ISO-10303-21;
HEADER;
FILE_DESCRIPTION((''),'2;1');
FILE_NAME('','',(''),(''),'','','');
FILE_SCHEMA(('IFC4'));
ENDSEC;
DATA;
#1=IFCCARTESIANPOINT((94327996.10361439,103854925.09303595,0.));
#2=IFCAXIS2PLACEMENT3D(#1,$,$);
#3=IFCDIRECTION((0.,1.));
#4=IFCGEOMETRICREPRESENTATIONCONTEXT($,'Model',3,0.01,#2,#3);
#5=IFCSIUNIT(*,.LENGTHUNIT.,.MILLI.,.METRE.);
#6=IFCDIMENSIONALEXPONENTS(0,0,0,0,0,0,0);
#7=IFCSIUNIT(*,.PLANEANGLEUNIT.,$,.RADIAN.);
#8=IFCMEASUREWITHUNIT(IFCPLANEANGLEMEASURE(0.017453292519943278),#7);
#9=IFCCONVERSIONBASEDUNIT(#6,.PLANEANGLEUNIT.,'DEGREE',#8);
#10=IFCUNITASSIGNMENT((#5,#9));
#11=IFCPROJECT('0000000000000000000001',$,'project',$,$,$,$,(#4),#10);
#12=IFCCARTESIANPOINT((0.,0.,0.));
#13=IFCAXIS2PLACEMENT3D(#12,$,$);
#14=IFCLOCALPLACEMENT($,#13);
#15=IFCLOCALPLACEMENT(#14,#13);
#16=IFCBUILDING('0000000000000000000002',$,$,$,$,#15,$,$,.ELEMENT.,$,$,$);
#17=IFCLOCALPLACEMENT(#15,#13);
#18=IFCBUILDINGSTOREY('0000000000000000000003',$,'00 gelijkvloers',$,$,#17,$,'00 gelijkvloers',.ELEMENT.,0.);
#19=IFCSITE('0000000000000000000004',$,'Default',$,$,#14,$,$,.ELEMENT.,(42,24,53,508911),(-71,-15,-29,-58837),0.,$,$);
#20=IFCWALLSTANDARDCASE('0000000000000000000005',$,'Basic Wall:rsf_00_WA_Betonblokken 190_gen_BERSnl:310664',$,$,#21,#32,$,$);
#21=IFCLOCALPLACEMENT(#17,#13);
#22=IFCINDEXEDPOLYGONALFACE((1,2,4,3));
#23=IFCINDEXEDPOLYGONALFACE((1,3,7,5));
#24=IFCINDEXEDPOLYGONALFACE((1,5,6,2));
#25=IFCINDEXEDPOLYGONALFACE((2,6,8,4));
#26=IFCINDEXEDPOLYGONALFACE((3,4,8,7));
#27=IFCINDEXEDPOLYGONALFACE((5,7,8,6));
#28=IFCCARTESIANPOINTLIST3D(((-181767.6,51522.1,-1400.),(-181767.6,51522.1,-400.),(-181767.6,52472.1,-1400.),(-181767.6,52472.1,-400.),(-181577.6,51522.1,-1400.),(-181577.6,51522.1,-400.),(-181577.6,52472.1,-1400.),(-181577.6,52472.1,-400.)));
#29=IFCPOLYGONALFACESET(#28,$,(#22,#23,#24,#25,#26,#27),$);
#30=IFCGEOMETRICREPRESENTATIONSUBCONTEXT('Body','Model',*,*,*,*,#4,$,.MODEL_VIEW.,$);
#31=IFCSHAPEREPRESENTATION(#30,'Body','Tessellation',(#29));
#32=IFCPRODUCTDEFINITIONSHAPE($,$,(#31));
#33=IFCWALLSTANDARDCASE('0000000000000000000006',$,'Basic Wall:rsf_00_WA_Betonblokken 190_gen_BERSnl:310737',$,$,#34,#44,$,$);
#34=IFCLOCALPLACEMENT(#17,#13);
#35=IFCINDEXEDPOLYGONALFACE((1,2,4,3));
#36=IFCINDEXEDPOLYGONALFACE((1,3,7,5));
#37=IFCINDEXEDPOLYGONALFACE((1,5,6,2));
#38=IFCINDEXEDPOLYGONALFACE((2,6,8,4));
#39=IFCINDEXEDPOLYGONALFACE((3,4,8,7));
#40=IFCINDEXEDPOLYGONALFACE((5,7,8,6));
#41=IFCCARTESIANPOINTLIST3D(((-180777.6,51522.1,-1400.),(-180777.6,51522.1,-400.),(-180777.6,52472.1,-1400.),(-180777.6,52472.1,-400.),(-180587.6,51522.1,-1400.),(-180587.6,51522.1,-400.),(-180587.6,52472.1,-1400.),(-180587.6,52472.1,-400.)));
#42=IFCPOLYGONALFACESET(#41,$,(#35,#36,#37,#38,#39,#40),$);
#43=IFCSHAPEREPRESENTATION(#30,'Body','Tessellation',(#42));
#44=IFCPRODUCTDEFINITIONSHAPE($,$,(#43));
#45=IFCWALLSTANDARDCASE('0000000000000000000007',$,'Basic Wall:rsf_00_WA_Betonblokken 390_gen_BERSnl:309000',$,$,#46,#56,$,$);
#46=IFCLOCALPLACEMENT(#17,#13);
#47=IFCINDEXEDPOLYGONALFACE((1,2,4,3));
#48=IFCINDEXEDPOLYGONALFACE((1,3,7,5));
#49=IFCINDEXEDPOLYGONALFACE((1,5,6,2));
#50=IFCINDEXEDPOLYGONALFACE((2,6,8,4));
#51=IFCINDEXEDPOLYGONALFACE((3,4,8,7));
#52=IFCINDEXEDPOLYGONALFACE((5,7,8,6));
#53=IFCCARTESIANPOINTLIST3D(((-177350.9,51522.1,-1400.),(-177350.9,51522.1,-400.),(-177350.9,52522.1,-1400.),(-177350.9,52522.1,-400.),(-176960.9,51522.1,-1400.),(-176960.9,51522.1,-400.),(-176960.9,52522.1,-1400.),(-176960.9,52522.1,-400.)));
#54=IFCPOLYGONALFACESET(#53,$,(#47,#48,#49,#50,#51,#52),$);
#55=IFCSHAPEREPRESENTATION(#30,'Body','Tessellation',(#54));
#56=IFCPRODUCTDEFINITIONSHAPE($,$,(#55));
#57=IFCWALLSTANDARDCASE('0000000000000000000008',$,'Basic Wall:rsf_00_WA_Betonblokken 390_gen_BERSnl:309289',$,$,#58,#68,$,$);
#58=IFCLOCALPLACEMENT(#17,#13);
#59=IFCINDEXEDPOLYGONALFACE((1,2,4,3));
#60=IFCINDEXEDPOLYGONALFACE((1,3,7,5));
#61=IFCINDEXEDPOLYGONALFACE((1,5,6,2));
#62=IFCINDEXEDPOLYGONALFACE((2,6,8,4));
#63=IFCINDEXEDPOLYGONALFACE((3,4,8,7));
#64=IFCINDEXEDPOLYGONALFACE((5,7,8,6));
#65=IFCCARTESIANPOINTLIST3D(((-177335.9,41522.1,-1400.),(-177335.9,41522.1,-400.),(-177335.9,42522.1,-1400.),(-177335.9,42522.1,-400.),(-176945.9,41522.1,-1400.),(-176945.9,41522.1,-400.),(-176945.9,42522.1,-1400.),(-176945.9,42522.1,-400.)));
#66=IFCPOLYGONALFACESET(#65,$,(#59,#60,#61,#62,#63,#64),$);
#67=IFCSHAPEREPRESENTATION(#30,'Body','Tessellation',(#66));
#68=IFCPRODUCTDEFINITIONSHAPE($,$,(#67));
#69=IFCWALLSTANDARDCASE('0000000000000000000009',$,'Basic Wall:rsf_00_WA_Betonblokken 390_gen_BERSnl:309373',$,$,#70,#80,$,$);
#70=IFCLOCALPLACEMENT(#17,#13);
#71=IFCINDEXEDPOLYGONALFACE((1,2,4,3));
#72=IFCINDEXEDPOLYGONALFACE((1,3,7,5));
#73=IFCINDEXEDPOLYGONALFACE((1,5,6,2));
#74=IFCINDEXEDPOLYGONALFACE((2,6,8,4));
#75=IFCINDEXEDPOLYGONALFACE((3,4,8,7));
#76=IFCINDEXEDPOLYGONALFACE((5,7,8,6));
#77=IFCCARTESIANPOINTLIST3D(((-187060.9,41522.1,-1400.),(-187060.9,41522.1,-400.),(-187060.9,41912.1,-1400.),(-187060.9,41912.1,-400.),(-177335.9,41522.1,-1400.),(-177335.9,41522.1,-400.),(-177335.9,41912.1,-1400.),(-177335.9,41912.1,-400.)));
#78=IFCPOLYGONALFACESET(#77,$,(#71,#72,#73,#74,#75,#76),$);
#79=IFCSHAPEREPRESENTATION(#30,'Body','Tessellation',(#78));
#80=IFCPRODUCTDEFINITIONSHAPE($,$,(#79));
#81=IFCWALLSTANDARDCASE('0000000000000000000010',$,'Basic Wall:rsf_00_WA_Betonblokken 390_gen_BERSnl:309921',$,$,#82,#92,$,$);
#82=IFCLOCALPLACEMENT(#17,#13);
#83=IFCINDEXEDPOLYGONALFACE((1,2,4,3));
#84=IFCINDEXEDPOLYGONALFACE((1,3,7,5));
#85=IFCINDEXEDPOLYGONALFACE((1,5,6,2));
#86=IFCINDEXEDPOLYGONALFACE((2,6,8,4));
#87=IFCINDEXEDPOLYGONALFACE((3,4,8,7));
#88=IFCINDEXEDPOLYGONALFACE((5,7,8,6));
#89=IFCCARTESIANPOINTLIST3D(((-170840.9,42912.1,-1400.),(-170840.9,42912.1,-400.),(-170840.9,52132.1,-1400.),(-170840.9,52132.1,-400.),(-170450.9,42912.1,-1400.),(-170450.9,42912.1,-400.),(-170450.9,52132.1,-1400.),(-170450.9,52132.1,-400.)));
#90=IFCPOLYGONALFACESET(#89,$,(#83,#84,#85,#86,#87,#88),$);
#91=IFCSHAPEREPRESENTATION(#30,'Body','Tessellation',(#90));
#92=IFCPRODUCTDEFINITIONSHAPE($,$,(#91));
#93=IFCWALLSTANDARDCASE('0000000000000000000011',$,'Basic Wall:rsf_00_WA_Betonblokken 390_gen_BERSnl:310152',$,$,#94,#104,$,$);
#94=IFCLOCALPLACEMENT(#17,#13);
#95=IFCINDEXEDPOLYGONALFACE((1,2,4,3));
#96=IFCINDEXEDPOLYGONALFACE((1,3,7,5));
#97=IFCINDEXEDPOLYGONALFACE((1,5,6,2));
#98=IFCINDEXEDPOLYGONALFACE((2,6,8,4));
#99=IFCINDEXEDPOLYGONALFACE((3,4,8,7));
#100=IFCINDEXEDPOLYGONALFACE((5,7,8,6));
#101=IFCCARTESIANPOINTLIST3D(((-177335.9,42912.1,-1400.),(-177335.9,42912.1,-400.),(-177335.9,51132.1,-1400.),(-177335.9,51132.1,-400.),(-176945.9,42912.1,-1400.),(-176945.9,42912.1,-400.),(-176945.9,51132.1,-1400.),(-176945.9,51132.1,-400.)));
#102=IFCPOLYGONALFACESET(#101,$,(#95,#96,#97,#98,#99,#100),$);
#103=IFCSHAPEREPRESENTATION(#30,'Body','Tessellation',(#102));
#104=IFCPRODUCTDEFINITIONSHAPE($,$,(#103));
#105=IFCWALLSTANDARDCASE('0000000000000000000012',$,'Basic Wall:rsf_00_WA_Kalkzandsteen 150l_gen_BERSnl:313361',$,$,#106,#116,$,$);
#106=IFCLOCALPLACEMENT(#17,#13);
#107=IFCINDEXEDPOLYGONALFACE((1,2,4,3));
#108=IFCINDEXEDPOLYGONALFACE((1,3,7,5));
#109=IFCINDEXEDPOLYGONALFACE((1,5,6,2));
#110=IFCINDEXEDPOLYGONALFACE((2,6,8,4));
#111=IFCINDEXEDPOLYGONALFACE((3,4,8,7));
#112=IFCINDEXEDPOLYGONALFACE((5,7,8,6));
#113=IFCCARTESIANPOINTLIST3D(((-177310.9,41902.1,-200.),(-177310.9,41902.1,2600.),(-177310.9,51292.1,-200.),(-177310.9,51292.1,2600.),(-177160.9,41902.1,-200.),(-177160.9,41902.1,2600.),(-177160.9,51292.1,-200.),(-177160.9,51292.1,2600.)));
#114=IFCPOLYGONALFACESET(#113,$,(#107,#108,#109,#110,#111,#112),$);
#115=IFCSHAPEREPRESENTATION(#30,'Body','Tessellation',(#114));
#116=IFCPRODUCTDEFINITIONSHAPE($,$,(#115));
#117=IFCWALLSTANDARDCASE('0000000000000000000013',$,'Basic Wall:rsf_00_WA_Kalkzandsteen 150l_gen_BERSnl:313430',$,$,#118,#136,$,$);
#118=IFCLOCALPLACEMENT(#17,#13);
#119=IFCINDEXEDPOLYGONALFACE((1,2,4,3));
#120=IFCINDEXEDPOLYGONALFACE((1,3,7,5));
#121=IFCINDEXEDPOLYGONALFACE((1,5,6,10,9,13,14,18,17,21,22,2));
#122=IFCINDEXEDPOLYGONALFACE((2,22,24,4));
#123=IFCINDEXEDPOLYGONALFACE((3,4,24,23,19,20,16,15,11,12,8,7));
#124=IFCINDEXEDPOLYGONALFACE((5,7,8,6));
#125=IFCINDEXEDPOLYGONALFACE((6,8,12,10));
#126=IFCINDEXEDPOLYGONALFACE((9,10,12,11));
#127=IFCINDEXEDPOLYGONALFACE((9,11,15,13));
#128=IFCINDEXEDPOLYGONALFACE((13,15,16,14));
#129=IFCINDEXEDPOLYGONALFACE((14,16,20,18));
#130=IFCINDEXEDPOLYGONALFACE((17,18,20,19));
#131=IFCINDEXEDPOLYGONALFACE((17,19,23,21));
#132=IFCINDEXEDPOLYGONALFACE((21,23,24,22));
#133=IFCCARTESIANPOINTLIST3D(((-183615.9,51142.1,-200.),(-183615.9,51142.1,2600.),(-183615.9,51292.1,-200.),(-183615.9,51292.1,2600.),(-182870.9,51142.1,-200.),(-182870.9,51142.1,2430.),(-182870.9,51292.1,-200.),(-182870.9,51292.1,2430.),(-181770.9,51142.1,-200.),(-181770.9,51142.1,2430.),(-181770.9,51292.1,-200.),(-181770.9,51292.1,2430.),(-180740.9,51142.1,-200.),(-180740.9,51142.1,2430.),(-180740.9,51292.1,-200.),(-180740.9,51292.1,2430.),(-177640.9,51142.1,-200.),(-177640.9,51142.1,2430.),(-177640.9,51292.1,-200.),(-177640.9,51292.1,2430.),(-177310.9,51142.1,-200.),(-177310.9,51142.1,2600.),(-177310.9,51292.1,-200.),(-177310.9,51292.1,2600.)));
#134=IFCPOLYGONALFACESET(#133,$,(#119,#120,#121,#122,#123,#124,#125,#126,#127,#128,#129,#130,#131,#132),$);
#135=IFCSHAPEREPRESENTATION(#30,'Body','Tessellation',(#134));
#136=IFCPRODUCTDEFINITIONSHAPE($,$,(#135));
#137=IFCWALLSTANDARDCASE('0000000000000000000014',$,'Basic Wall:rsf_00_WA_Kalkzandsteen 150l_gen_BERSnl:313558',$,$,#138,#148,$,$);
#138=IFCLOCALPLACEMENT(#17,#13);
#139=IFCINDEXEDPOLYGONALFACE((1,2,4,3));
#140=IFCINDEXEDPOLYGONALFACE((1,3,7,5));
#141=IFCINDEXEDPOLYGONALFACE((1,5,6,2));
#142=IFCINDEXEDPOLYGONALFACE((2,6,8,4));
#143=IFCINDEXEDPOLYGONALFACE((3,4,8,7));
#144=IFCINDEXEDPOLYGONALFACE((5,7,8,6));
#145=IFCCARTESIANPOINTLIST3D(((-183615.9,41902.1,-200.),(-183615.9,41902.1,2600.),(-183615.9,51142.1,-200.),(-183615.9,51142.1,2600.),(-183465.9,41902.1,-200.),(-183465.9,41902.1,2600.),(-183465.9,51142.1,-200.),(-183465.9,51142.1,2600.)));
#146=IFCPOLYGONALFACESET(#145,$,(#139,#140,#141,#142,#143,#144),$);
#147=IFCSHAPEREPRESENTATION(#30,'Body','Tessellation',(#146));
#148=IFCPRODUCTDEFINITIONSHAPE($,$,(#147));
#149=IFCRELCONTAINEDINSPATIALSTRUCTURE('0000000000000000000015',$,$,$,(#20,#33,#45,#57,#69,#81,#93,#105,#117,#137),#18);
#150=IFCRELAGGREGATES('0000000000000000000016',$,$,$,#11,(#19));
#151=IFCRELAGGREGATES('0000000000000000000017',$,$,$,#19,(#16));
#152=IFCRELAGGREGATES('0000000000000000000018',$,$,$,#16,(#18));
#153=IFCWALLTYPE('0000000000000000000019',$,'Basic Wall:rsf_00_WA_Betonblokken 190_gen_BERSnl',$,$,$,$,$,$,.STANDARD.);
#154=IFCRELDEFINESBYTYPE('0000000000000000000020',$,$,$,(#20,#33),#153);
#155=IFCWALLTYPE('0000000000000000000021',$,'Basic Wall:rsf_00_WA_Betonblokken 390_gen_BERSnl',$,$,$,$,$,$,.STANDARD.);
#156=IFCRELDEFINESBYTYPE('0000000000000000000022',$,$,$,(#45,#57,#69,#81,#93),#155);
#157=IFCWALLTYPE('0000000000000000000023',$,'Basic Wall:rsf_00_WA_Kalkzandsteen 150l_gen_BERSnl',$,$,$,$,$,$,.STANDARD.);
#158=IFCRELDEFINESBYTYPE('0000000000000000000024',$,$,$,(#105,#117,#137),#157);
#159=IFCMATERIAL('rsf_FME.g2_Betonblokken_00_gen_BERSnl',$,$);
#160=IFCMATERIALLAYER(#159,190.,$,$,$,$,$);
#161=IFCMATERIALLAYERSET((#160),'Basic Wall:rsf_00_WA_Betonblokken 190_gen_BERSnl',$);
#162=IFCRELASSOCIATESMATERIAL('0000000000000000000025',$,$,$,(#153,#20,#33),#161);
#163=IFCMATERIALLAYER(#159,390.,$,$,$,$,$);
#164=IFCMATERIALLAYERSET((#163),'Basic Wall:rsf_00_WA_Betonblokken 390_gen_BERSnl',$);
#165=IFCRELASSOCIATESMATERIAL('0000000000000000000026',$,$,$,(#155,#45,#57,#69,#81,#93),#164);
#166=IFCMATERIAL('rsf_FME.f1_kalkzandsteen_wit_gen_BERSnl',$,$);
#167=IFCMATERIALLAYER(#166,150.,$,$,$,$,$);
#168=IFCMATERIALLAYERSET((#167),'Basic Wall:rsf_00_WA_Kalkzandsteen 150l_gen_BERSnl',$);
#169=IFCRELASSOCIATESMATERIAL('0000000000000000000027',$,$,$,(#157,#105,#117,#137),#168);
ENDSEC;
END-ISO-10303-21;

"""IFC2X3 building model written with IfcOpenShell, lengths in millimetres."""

from ifc_helpers import new_model, entity, si_unit, converted_unit, direction, frame, frame_2d, origin, place, context, subcontext, project, spatial, polyline, rectangle, extrude, clip, bounded_halfspace, material, layer, layer_set, layer_usage, type_object, element, save


model = new_model("IFC2X3")

# Units and contexts
model_context = context("Model", 3, precision=0.01, world=frame((94327996.10361439, 103854925.09303595, 0.0)), true_north=direction((0.0, 1.0)))
body_context = subcontext(model_context, "Body", "Model", "MODEL_VIEW")
ifc_project = project(units=[si_unit("LENGTHUNIT", "METRE", prefix="MILLI"), converted_unit("PLANEANGLEUNIT", "DEGREE", entity("IfcPlaneAngleMeasure", 0.017453292519943278), si_unit("PLANEANGLEUNIT", "RADIAN"), dimensions=[0, 0, 0, 0, 0, 0, 0])], contexts=[model_context])

# Site, building, storey
site_placement = place(None, origin())
site = spatial("IfcSite", under=ifc_project, at=site_placement, Name="Default", CompositionType="ELEMENT", RefLatitude=(42, 24, 53, 508911), RefLongitude=(-71, -15, -29, -58837), RefElevation=0.0)
building_placement = place(site_placement, origin())
building = spatial("IfcBuilding", under=site, at=building_placement, CompositionType="ELEMENT")
storey_placement = place(building_placement, origin())
storey = spatial("IfcBuildingStorey", under=building, at=storey_placement, Name="00 gelijkvloers", LongName="00 gelijkvloers", CompositionType="ELEMENT", Elevation=0.0)

# Walls
ifc_material_1 = material(Name="rsf_FME.g2_Betonblokken_00_gen_BERSnl")
ifc_layer_1 = layer(ifc_material_1, 190.0)
ifc_layer_set_1 = layer_set([ifc_layer_1], Name="Basic Wall:rsf_00_WA_Betonblokken 190_gen_BERSnl")
ifc_layer_usage_1 = layer_usage(ifc_layer_set_1, "AXIS2", "NEGATIVE", 95.0)
wall_type_1 = type_object("IfcWallType", Name="Basic Wall:rsf_00_WA_Betonblokken 190_gen_BERSnl", PredefinedType="STANDARD", material=ifc_layer_set_1)
wall_1_placement = place(storey_placement, frame((-181672.6, 51522.1, -1400.0), z_axis=(0.0, 0.0, 1.0), x_axis=(0.0, 1.0, 0.0)))
element("IfcWallStandardCase", 1, at=wall_1_placement, inside=storey, type_object=wall_type_1, material=ifc_layer_usage_1, Name="Basic Wall:rsf_00_WA_Betonblokken 190_gen_BERSnl:310664", context=body_context, shape_type="SweptSolid", body=[
    extrude(rectangle(XDim=950.0, YDim=190.0, at=frame_2d((475.0, 0.0), x_axis=(-1.0, 0.0))), origin(), (0.0, 0.0, 1.0), 1000.0),
])
ifc_layer_usage_2 = layer_usage(ifc_layer_set_1, "AXIS2", "NEGATIVE", 95.0)
wall_2_placement = place(storey_placement, frame((-180682.6, 51522.1, -1400.0), z_axis=(0.0, 0.0, 1.0), x_axis=(0.0, 1.0, 0.0)))
element("IfcWallStandardCase", 2, at=wall_2_placement, inside=storey, type_object=wall_type_1, material=ifc_layer_usage_2, Name="Basic Wall:rsf_00_WA_Betonblokken 190_gen_BERSnl:310737", context=body_context, shape_type="SweptSolid", body=[
    extrude(rectangle(XDim=950.0, YDim=190.0, at=frame_2d((475.0, 0.0), x_axis=(-1.0, 0.0))), origin(), (0.0, 0.0, 1.0), 1000.0),
])
ifc_layer_2 = layer(ifc_material_1, 390.0)
ifc_layer_set_2 = layer_set([ifc_layer_2], Name="Basic Wall:rsf_00_WA_Betonblokken 390_gen_BERSnl")
ifc_layer_usage_3 = layer_usage(ifc_layer_set_2, "AXIS2", "NEGATIVE", 195.0)
wall_type_2 = type_object("IfcWallType", Name="Basic Wall:rsf_00_WA_Betonblokken 390_gen_BERSnl", PredefinedType="STANDARD", material=ifc_layer_set_2)
wall_3_placement = place(storey_placement, frame((-177155.9, 51522.1, -1400.0), z_axis=(0.0, 0.0, 1.0), x_axis=(0.0, 1.0, 0.0)))
element("IfcWallStandardCase", 3, at=wall_3_placement, inside=storey, type_object=wall_type_2, material=ifc_layer_usage_3, Name="Basic Wall:rsf_00_WA_Betonblokken 390_gen_BERSnl:309000", context=body_context, shape_type="SweptSolid", body=[
    extrude(rectangle(XDim=1000.0, YDim=390.0, at=frame_2d((500.0, 0.0), x_axis=(-1.0, 0.0))), origin(), (0.0, 0.0, 1.0), 1000.0),
])
ifc_layer_usage_4 = layer_usage(ifc_layer_set_2, "AXIS2", "NEGATIVE", 195.0)
wall_4_placement = place(storey_placement, frame((-177140.9, 42522.1, -1400.0), z_axis=(0.0, 0.0, 1.0), x_axis=(0.0, -1.0, 0.0)))
element("IfcWallStandardCase", 4, at=wall_4_placement, inside=storey, type_object=wall_type_2, material=ifc_layer_usage_4, Name="Basic Wall:rsf_00_WA_Betonblokken 390_gen_BERSnl:309289", context=body_context, shape_type="SweptSolid", body=[
    extrude(rectangle(XDim=1000.0, YDim=390.0, at=frame_2d((500.0, 0.0), x_axis=(-1.0, 0.0))), origin(), (0.0, 0.0, 1.0), 1000.0),
])
ifc_layer_usage_5 = layer_usage(ifc_layer_set_2, "AXIS2", "NEGATIVE", 195.0)
wall_5_placement = place(storey_placement, frame((-177335.9, 41717.1, -1400.0), z_axis=(0.0, 0.0, 1.0), x_axis=(-1.0, 0.0, 0.0)))
element("IfcWallStandardCase", 5, at=wall_5_placement, inside=storey, type_object=wall_type_2, material=ifc_layer_usage_5, Name="Basic Wall:rsf_00_WA_Betonblokken 390_gen_BERSnl:309373", context=body_context, shape_type="SweptSolid", body=[
    extrude(rectangle(XDim=9725.0, YDim=390.0, at=frame_2d((4862.5, 0.0), x_axis=(-1.0, 0.0))), origin(), (0.0, 0.0, 1.0), 1000.0),
])
ifc_layer_usage_6 = layer_usage(ifc_layer_set_2, "AXIS2", "POSITIVE", -195.0)
wall_6_placement = place(storey_placement, frame((-170645.9, 42912.1, -1400.0), z_axis=(0.0, 0.0, 1.0), x_axis=(0.0, 1.0, 0.0)))
element("IfcWallStandardCase", 6, at=wall_6_placement, inside=storey, type_object=wall_type_2, material=ifc_layer_usage_6, Name="Basic Wall:rsf_00_WA_Betonblokken 390_gen_BERSnl:309921", context=body_context, shape_type="SweptSolid", body=[
    extrude(rectangle(XDim=9220.0, YDim=390.0, at=frame_2d((4610.0, 0.0), x_axis=(-1.0, 0.0))), origin(), (0.0, 0.0, 1.0), 1000.0),
])
ifc_layer_usage_7 = layer_usage(ifc_layer_set_2, "AXIS2", "POSITIVE", -195.0)
wall_7_placement = place(storey_placement, frame((-177140.9, 42912.1, -1400.0), z_axis=(0.0, 0.0, 1.0), x_axis=(0.0, 1.0, 0.0)))
element("IfcWallStandardCase", 7, at=wall_7_placement, inside=storey, type_object=wall_type_2, material=ifc_layer_usage_7, Name="Basic Wall:rsf_00_WA_Betonblokken 390_gen_BERSnl:310152", context=body_context, shape_type="SweptSolid", body=[
    extrude(rectangle(XDim=8220.0, YDim=390.0, at=frame_2d((4110.0, 0.0), x_axis=(-1.0, 0.0))), origin(), (0.0, 0.0, 1.0), 1000.0),
])
ifc_material_2 = material(Name="rsf_FME.f1_kalkzandsteen_wit_gen_BERSnl")
ifc_layer_3 = layer(ifc_material_2, 150.0)
ifc_layer_set_3 = layer_set([ifc_layer_3], Name="Basic Wall:rsf_00_WA_Kalkzandsteen 150l_gen_BERSnl")
ifc_layer_usage_8 = layer_usage(ifc_layer_set_3, "AXIS2", "NEGATIVE", 75.0)
wall_type_3 = type_object("IfcWallType", Name="Basic Wall:rsf_00_WA_Kalkzandsteen 150l_gen_BERSnl", PredefinedType="STANDARD", material=ifc_layer_set_3)
wall_8_placement = place(storey_placement, frame((-177235.9, 41902.1, -200.0), z_axis=(0.0, 0.0, 1.0), x_axis=(0.0, 1.0, 0.0)))
element("IfcWallStandardCase", 8, at=wall_8_placement, inside=storey, type_object=wall_type_3, material=ifc_layer_usage_8, Name="Basic Wall:rsf_00_WA_Kalkzandsteen 150l_gen_BERSnl:313361", context=body_context, shape_type="Clipping", body=[
    clip(extrude(rectangle(XDim=9390.0, YDim=150.0, at=frame_2d((4695.0, 0.0), x_axis=(-1.0, 0.0))), origin(), (0.0, 0.0, 1.0), 2800.0), bounded_halfspace(frame((0.0, -75.0, 2800.0), z_axis=(0.0, 0.0, -1.0), x_axis=(0.0, -1.0, 0.0)), True, frame((0.0, -75.0, 2800.0)), polyline([(0.0, 0.0), (850.0, 0.0), (9390.0, 0.0), (9390.0, 150.0), (9240.0, 150.0), (0.0, 150.0), (0.0, 0.0)]))),
])

# Wall, openings
ifc_layer_usage_9 = layer_usage(ifc_layer_set_3, "AXIS2", "NEGATIVE", 75.0)
wall_9_placement = place(storey_placement, frame((-177310.9, 51217.1, -200.0), z_axis=(0.0, 0.0, 1.0), x_axis=(-1.0, 0.0, 0.0)))
wall_9 = element("IfcWallStandardCase", 9, at=wall_9_placement, inside=storey, type_object=wall_type_3, material=ifc_layer_usage_9, Name="Basic Wall:rsf_00_WA_Kalkzandsteen 150l_gen_BERSnl:313430", context=body_context, shape_type="Clipping", body=[
    clip(extrude(rectangle(XDim=6305.0, YDim=150.0, at=frame_2d((3152.5, 0.0), x_axis=(-1.0, 0.0))), origin(), (0.0, 0.0, 1.0), 2800.0), bounded_halfspace(frame((0.0, -75.0, 2800.0), z_axis=(0.0, 0.0, -1.0), x_axis=(-1.0, 0.0, 0.0)), True, frame((0.0, -75.0, 2800.0)), polyline([(0.0, 0.0), (6305.0, 0.0), (6305.0, 150.0), (6155.0, 150.0), (0.0, 150.0), (0.0, 0.0)]))),
])
opening_1_placement = place(wall_9_placement, frame((-177310.9, 51217.1, 200.0), z_axis=(0.0, 0.0, 1.0), x_axis=(-1.0, 0.0, 0.0)))
element("IfcOpeningElement", 10, at=opening_1_placement, cuts=wall_9, ObjectType="Opening", context=body_context, shape_type="SweptSolid", body=[
    extrude(rectangle(XDim=2630.0, YDim=3100.0, at=frame_2d((0.0, 0.0), x_axis=(0.0, 1.0))), frame((-179190.9, 52816.1, 1115.0), z_axis=(0.0, -1.0, 0.0), x_axis=(1.0, 0.0, 0.0)), (0.0, 0.0, 1.0), 3048.0),
])
opening_2_placement = place(wall_9_placement, frame((-177310.9, 51217.1, 200.0), z_axis=(0.0, 0.0, 1.0), x_axis=(-1.0, 0.0, 0.0)))
element("IfcOpeningElement", 11, at=opening_2_placement, cuts=wall_9, ObjectType="Opening", context=body_context, shape_type="SweptSolid", body=[
    extrude(rectangle(XDim=2630.0, YDim=1100.0, at=frame_2d((0.0, 0.0), x_axis=(1.0, 0.0))), frame((-182320.9, 52666.1, 1115.0), z_axis=(0.0, -1.0, 0.0), x_axis=(0.0, 0.0, 1.0)), (0.0, 0.0, 1.0), 3048.0),
])

# Wall
ifc_layer_usage_10 = layer_usage(ifc_layer_set_3, "AXIS2", "NEGATIVE", 75.0)
wall_10_placement = place(storey_placement, frame((-183540.9, 51142.1, -200.0), z_axis=(0.0, 0.0, 1.0), x_axis=(0.0, -1.0, 0.0)))
element("IfcWallStandardCase", 12, at=wall_10_placement, inside=storey, type_object=wall_type_3, material=ifc_layer_usage_10, Name="Basic Wall:rsf_00_WA_Kalkzandsteen 150l_gen_BERSnl:313558", context=body_context, shape_type="Clipping", body=[
    clip(extrude(rectangle(XDim=9240.0, YDim=150.0, at=frame_2d((4620.0, 0.0), x_axis=(-1.0, 0.0))), origin(), (0.0, 0.0, 1.0), 2800.0), bounded_halfspace(frame((0.0, -75.0, 2800.0), z_axis=(0.0, 0.0, -1.0), x_axis=(0.0, 1.0, 0.0)), True, frame((0.0, -75.0, 2800.0)), polyline([(0.0, 0.0), (9240.0, 0.0), (9240.0, 150.0), (0.0, 150.0), (0.0, 0.0)]))),
])

save(model, "model.ifc")
